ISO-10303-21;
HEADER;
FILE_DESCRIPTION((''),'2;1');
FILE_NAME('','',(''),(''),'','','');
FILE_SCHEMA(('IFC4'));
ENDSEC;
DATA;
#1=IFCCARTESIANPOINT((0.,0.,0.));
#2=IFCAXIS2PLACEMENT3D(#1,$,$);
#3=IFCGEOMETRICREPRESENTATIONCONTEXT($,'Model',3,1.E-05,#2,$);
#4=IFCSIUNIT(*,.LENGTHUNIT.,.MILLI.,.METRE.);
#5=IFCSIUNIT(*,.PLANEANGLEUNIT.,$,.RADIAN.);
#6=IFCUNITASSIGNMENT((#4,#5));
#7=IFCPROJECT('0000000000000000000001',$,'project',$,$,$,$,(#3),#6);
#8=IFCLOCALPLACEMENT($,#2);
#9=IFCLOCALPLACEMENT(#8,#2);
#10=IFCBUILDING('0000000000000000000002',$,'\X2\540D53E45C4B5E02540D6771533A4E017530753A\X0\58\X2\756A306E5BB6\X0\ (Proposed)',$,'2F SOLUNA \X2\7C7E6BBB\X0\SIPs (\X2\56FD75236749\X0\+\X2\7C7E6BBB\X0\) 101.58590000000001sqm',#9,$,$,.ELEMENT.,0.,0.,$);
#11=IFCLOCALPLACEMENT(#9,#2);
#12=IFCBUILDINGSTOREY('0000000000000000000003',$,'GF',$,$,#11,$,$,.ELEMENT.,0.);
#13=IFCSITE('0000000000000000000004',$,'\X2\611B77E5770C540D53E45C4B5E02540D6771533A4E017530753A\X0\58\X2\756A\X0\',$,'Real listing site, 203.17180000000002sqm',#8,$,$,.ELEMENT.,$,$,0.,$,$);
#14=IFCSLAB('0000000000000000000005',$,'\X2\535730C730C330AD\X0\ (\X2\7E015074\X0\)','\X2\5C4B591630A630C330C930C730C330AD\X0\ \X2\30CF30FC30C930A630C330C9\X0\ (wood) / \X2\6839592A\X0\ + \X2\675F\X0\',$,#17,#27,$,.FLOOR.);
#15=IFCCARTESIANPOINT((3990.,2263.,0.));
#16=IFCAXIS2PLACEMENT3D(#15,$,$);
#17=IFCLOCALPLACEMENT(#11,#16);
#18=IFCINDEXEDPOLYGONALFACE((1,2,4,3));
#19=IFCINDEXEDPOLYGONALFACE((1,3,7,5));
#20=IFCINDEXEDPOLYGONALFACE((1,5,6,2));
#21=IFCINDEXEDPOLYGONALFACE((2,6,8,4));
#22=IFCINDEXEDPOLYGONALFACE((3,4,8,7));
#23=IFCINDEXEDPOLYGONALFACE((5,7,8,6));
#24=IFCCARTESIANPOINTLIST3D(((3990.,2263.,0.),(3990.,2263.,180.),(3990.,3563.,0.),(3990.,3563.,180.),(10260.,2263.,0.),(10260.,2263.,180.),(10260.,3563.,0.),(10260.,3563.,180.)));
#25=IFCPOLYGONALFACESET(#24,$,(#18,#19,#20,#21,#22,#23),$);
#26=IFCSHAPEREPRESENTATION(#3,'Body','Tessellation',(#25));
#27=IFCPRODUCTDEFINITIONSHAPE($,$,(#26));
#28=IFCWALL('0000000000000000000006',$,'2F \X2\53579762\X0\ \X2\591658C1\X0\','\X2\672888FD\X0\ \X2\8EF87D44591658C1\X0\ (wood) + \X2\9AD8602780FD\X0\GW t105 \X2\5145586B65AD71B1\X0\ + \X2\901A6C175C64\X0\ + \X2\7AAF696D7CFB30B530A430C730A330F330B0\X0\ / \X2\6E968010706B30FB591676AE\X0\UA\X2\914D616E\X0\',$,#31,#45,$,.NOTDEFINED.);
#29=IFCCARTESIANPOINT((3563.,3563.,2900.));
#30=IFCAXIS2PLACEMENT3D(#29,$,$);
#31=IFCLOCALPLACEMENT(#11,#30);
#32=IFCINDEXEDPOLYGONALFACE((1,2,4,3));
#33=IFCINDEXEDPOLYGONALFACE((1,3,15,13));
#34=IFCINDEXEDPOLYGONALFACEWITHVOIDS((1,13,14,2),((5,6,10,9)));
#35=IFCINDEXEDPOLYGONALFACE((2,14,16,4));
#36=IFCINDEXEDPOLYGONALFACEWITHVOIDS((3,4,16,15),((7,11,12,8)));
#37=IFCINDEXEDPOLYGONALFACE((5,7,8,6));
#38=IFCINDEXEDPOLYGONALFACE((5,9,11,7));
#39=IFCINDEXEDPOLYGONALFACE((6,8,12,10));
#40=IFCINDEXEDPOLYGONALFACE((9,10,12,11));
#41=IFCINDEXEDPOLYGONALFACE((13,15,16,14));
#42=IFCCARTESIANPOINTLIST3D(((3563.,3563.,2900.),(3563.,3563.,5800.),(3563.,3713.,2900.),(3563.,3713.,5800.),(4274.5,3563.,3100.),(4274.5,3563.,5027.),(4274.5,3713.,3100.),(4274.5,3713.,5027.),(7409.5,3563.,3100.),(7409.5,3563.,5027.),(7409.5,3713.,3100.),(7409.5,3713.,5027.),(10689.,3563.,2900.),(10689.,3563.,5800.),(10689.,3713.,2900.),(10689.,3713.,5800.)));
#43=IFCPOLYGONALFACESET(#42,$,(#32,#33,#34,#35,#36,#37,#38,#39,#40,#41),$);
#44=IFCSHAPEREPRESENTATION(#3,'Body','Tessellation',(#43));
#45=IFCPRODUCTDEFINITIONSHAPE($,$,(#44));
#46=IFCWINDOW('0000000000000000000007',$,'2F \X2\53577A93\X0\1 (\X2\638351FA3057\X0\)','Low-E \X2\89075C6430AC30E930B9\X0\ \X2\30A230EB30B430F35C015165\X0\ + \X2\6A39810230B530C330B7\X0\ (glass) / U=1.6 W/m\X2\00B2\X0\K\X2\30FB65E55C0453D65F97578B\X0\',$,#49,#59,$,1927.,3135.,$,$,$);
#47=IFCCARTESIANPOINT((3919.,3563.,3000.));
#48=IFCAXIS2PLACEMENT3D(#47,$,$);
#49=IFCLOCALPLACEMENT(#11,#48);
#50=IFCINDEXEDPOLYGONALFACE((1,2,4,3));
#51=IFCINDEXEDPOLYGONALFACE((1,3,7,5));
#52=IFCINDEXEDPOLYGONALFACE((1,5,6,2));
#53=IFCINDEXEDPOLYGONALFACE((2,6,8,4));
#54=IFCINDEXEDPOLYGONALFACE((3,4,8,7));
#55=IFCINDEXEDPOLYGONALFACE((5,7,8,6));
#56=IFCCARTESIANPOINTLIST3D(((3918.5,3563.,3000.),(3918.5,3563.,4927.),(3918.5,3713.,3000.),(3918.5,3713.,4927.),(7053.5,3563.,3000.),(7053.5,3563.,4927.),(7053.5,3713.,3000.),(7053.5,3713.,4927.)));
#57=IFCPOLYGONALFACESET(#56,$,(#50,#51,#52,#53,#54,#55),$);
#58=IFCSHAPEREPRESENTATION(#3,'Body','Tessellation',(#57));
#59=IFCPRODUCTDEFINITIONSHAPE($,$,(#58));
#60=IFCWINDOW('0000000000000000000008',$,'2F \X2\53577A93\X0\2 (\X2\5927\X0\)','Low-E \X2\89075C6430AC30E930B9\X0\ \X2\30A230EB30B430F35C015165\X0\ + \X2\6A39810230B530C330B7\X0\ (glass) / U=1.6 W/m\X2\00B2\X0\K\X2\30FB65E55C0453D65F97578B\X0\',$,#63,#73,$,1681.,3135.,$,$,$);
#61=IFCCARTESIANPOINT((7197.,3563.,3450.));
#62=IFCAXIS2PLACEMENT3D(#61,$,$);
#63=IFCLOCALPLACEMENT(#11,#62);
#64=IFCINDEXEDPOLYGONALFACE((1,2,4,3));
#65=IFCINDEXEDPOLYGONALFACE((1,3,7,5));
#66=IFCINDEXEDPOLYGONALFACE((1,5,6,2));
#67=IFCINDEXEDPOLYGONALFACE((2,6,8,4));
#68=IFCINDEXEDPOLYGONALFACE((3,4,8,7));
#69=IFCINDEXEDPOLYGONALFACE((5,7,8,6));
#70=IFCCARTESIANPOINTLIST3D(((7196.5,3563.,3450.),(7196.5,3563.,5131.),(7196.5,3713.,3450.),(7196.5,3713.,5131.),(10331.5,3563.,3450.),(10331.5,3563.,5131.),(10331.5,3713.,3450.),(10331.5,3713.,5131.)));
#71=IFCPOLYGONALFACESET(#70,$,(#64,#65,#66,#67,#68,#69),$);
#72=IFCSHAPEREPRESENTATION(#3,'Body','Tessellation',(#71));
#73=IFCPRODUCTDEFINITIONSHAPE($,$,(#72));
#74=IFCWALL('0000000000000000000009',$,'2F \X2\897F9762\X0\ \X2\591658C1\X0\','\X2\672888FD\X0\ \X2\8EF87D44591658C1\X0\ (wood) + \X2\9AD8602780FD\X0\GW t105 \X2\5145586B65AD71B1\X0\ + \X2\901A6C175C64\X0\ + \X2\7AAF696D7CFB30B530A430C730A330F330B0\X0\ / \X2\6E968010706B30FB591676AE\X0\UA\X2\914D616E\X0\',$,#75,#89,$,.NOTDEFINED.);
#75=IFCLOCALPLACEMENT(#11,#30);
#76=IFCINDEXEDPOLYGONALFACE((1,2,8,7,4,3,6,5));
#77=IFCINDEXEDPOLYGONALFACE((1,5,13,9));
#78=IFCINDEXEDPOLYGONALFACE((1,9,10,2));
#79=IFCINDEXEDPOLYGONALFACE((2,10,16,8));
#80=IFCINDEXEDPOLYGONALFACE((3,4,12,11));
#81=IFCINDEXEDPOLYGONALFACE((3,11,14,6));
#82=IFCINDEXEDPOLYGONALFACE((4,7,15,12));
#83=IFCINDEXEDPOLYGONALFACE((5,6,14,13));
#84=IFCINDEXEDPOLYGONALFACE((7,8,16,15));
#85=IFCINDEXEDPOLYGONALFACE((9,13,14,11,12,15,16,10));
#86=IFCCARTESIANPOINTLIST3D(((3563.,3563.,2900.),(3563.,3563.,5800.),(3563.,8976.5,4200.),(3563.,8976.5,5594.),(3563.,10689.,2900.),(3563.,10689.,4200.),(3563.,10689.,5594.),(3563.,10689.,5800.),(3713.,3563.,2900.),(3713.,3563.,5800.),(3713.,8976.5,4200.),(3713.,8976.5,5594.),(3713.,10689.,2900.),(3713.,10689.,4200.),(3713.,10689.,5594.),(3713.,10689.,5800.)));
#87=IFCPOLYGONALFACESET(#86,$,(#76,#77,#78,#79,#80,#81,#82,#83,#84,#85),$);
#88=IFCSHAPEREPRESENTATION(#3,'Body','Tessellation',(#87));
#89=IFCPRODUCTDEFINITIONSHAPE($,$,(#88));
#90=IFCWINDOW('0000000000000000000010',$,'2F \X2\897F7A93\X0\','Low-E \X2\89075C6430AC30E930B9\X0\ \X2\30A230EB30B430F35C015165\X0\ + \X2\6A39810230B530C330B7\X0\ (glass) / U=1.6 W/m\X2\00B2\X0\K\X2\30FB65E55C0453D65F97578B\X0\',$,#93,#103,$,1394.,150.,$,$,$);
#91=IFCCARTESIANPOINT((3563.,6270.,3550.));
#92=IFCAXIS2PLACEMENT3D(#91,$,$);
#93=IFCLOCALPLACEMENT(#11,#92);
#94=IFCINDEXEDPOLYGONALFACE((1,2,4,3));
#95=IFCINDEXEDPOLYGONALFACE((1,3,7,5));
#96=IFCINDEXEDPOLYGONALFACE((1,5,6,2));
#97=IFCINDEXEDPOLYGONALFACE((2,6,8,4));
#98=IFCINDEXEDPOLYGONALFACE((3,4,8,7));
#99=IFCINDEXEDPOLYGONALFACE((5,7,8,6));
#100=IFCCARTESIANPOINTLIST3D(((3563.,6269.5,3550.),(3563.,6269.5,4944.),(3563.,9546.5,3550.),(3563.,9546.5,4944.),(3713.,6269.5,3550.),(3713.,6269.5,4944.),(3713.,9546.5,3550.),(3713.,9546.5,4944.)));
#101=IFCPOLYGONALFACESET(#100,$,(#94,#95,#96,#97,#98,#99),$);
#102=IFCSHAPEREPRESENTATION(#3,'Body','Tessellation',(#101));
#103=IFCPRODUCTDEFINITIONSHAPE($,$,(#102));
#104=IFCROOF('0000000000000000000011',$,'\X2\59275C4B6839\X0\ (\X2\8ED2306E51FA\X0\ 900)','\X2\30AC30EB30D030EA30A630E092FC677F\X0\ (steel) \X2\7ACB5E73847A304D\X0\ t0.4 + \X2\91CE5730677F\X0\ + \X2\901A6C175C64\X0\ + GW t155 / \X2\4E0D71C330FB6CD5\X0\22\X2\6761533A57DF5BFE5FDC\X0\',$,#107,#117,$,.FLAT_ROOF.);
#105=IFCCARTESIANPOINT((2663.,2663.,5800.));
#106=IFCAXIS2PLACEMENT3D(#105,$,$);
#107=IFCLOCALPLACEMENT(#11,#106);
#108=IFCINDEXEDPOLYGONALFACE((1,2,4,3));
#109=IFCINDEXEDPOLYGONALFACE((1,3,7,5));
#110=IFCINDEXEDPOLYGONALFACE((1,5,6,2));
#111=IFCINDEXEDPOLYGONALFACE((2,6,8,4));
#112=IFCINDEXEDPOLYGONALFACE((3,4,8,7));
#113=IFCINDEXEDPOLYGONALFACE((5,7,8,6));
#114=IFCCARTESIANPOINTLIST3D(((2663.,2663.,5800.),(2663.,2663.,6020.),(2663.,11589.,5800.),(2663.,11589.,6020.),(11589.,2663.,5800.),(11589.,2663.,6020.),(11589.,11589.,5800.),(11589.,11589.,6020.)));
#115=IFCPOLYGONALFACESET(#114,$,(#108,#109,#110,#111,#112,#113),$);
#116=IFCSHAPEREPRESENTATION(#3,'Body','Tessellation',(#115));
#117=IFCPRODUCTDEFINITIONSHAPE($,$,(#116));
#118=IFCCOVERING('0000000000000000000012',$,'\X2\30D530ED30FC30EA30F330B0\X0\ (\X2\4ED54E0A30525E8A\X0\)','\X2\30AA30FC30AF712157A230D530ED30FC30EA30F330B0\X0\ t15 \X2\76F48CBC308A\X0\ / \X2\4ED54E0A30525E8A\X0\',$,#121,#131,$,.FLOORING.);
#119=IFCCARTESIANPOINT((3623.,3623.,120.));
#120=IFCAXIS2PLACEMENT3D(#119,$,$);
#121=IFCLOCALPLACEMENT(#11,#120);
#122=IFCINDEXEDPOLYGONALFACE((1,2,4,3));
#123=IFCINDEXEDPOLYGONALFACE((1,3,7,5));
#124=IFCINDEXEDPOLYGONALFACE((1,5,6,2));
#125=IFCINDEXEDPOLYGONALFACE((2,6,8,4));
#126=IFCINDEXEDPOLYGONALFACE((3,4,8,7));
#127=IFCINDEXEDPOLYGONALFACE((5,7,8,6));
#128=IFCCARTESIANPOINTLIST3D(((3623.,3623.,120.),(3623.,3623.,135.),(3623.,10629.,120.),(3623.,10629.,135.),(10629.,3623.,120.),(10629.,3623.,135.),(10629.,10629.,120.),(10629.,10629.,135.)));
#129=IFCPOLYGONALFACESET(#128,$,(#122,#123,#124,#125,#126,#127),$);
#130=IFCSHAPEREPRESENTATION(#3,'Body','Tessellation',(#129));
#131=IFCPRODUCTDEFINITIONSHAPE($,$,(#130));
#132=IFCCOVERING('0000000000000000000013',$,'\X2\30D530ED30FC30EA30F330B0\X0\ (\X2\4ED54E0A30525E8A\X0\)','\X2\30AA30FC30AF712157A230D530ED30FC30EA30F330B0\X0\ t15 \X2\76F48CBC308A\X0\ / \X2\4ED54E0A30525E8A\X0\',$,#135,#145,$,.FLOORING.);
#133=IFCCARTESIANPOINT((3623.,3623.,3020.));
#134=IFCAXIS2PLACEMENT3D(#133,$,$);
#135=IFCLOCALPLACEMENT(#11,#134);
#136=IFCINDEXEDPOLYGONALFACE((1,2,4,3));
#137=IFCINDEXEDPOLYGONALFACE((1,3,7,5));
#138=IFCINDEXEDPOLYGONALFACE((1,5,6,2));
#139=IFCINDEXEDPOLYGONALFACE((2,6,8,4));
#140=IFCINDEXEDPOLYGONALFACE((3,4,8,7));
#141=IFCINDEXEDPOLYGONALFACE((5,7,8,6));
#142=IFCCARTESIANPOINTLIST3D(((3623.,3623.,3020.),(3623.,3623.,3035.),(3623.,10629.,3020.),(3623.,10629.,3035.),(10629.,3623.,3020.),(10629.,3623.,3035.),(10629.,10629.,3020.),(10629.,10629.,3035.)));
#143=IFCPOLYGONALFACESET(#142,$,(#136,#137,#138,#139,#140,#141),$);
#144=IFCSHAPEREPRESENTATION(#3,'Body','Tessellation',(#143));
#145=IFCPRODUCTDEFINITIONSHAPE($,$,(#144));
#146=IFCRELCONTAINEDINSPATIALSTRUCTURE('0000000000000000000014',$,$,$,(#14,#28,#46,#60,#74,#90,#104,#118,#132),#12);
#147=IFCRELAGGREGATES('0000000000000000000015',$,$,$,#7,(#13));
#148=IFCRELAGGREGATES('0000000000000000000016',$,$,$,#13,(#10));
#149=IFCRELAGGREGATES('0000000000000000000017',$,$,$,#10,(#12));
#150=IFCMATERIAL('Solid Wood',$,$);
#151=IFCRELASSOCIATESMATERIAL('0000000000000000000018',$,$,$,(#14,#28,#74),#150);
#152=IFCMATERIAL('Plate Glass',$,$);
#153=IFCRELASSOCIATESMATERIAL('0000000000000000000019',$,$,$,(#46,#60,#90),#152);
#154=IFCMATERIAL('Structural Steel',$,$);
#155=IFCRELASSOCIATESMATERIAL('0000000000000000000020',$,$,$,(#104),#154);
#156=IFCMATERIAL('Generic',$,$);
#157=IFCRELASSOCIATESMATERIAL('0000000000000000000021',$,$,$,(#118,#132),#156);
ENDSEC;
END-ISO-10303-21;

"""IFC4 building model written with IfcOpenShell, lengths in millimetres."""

from ifc_helpers import new_model, si_unit, frame, frame_2d, origin, place, context, project, spatial, rectangle, extrude, material, element, fill, save


model = new_model("IFC4")

# Units and contexts
model_context = context("Model", 3, precision=1e-05, world=origin())
ifc_project = project(units=[si_unit("LENGTHUNIT", "METRE", prefix="MILLI"), si_unit("PLANEANGLEUNIT", "RADIAN")], contexts=[model_context])

# Site, building, storey
site_placement = place(None, origin())
site = spatial("IfcSite", under=ifc_project, at=site_placement, Name="愛知県名古屋市名東区丁田町58番", ObjectType="Real listing site, 203.17180000000002sqm", CompositionType="ELEMENT", RefElevation=0.0)
building_placement = place(site_placement, origin())
building = spatial("IfcBuilding", under=site, at=building_placement, Name="名古屋市名東区丁田町58番の家 (Proposed)", ObjectType="2F SOLUNA 籾殻SIPs (国産杉+籾殻) 101.58590000000001sqm", CompositionType="ELEMENT", ElevationOfRefHeight=0.0, ElevationOfTerrain=0.0)
storey_placement = place(building_placement, origin())
storey = spatial("IfcBuildingStorey", under=building, at=storey_placement, Name="GF", CompositionType="ELEMENT", Elevation=0.0)

# Slab
ifc_material_1 = material(Name="Solid Wood")
slab_1_placement = place(storey_placement, frame((3990.0, 2263.0, 0.0)))
element("IfcSlab", 1, at=slab_1_placement, inside=storey, material=ifc_material_1, Name="南デッキ (縁側)", Description="屋外ウッドデッキ ハードウッド (wood) / 根太 + 束", PredefinedType="FLOOR", context=model_context, shape_type="SweptSolid", body=[
    extrude(rectangle(XDim=6270.0, YDim=1300.0, at=frame_2d((3135.0, 650.0))), frame((3990.0, 2263.0, 0.0)), (0.0, 0.0, 1.0), 180.0),
])

# Shared definitions
ifc_material_2 = material(Name="Plate Glass")

# Wall, openings, windows
wall_1_placement = place(storey_placement, frame((3563.0, 3563.0, 2900.0)))
wall_1 = element("IfcWall", 2, at=wall_1_placement, inside=storey, material=ifc_material_1, Name="2F 南面 外壁", Description="木製 軸組外壁 (wood) + 高性能GW t105 充填断熱 + 通気層 + 窯業系サイディング / 準耐火・外皮UA配慮", PredefinedType="NOTDEFINED", context=model_context, shape_type="SweptSolid", body=[
    extrude(rectangle(XDim=7126.0, YDim=150.0, at=frame_2d((3563.0, 75.0))), frame((3563.0, 3563.0, 2900.0)), (0.0, 0.0, 1.0), 2900.0),
])
opening_1_placement = place(storey_placement, frame((3919.0, 3563.0, 3000.0)))
opening_1 = element("IfcOpeningElement", 3, at=opening_1_placement, cuts=wall_1, PredefinedType="NOTDEFINED", context=model_context, shape_type="SweptSolid", body=[
    extrude(rectangle(XDim=3135.0, YDim=150.0, at=frame_2d((1567.0, 75.0))), frame((3919.0, 3563.0, 3000.0)), (0.0, 0.0, 1.0), 1927.0),
])
opening_2_placement = place(storey_placement, frame((7197.0, 3563.0, 3450.0)))
opening_2 = element("IfcOpeningElement", 4, at=opening_2_placement, cuts=wall_1, PredefinedType="NOTDEFINED", context=model_context, shape_type="SweptSolid", body=[
    extrude(rectangle(XDim=3135.0, YDim=150.0, at=frame_2d((1567.0, 75.0))), frame((7197.0, 3563.0, 3450.0)), (0.0, 0.0, 1.0), 1681.0),
])
window_1_placement = place(storey_placement, frame((3919.0, 3563.0, 3000.0)))
window_1 = element("IfcWindow", 5, at=window_1_placement, inside=storey, material=ifc_material_2, Name="2F 南窓1 (掃出し)", Description="Low-E 複層ガラス アルゴン封入 + 樹脂サッシ (glass) / U=1.6 W/m²K・日射取得型", OverallHeight=1927.0, OverallWidth=3135.0, context=model_context, shape_type="SweptSolid", body=[
    extrude(rectangle(XDim=3135.0, YDim=150.0, at=frame_2d((1567.0, 75.0))), frame((3919.0, 3563.0, 3000.0)), (0.0, 0.0, 1.0), 1927.0),
])
fill(opening_1, window_1)
window_2_placement = place(storey_placement, frame((7197.0, 3563.0, 3450.0)))
window_2 = element("IfcWindow", 6, at=window_2_placement, inside=storey, material=ifc_material_2, Name="2F 南窓2 (大)", Description="Low-E 複層ガラス アルゴン封入 + 樹脂サッシ (glass) / U=1.6 W/m²K・日射取得型", OverallHeight=1681.0, OverallWidth=3135.0, context=model_context, shape_type="SweptSolid", body=[
    extrude(rectangle(XDim=3135.0, YDim=150.0, at=frame_2d((1567.0, 75.0))), frame((7197.0, 3563.0, 3450.0)), (0.0, 0.0, 1.0), 1681.0),
])
fill(opening_2, window_2)

# Wall, opening, window
wall_2_placement = place(storey_placement, frame((3563.0, 3563.0, 2900.0)))
wall_2 = element("IfcWall", 7, at=wall_2_placement, inside=storey, material=ifc_material_1, Name="2F 西面 外壁", Description="木製 軸組外壁 (wood) + 高性能GW t105 充填断熱 + 通気層 + 窯業系サイディング / 準耐火・外皮UA配慮", PredefinedType="NOTDEFINED", context=model_context, shape_type="SweptSolid", body=[
    extrude(rectangle(XDim=150.0, YDim=7126.0, at=frame_2d((75.0, 3563.0))), frame((3563.0, 3563.0, 2900.0)), (0.0, 0.0, 1.0), 2900.0),
])
opening_3_placement = place(storey_placement, frame((3563.0, 6270.0, 3550.0)))
opening_3 = element("IfcOpeningElement", 8, at=opening_3_placement, cuts=wall_2, PredefinedType="NOTDEFINED", context=model_context, shape_type="SweptSolid", body=[
    extrude(rectangle(XDim=150.0, YDim=3277.0, at=frame_2d((75.0, 1638.0))), frame((3563.0, 6270.0, 3550.0)), (0.0, 0.0, 1.0), 1394.0),
])
window_3_placement = place(storey_placement, frame((3563.0, 6270.0, 3550.0)))
window_3 = element("IfcWindow", 9, at=window_3_placement, inside=storey, material=ifc_material_2, Name="2F 西窓", Description="Low-E 複層ガラス アルゴン封入 + 樹脂サッシ (glass) / U=1.6 W/m²K・日射取得型", OverallHeight=1394.0, OverallWidth=150.0, context=model_context, shape_type="SweptSolid", body=[
    extrude(rectangle(XDim=150.0, YDim=3277.0, at=frame_2d((75.0, 1638.0))), frame((3563.0, 6270.0, 3550.0)), (0.0, 0.0, 1.0), 1394.0),
])
fill(opening_3, window_3)

# Roof
ifc_material_3 = material(Name="Structural Steel")
roof_placement = place(storey_placement, frame((2663.0, 2663.0, 5800.0)))
element("IfcRoof", 10, at=roof_placement, inside=storey, material=ifc_material_3, Name="大屋根 (軒の出 900)", Description="ガルバリウム鋼板 (steel) 立平葺き t0.4 + 野地板 + 通気層 + GW t155 / 不燃・法22条区域対応", PredefinedType="FLAT_ROOF", context=model_context, shape_type="SweptSolid", body=[
    extrude(rectangle(XDim=8926.0, YDim=8926.0, at=frame_2d((4463.0, 4463.0))), frame((2663.0, 2663.0, 5800.0)), (0.0, 0.0, 1.0), 220.0),
])

# Coverings
ifc_material_4 = material(Name="Generic")
covering_1_placement = place(storey_placement, frame((3623.0, 3623.0, 120.0)))
element("IfcCovering", 11, at=covering_1_placement, inside=storey, material=ifc_material_4, Name="フローリング (仕上げ床)", Description="オーク無垢フローリング t15 直貼り / 仕上げ床", PredefinedType="FLOORING", context=model_context, shape_type="SweptSolid", body=[
    extrude(rectangle(XDim=7006.0, YDim=7006.0, at=frame_2d((3503.0, 3503.0))), frame((3623.0, 3623.0, 120.0)), (0.0, 0.0, 1.0), 15.0),
])
covering_2_placement = place(storey_placement, frame((3623.0, 3623.0, 3020.0)))
element("IfcCovering", 12, at=covering_2_placement, inside=storey, material=ifc_material_4, Name="フローリング (仕上げ床)", Description="オーク無垢フローリング t15 直貼り / 仕上げ床", PredefinedType="FLOORING", context=model_context, shape_type="SweptSolid", body=[
    extrude(rectangle(XDim=7006.0, YDim=7006.0, at=frame_2d((3503.0, 3503.0))), frame((3623.0, 3623.0, 3020.0)), (0.0, 0.0, 1.0), 15.0),
])

save(model, "model.ifc")
